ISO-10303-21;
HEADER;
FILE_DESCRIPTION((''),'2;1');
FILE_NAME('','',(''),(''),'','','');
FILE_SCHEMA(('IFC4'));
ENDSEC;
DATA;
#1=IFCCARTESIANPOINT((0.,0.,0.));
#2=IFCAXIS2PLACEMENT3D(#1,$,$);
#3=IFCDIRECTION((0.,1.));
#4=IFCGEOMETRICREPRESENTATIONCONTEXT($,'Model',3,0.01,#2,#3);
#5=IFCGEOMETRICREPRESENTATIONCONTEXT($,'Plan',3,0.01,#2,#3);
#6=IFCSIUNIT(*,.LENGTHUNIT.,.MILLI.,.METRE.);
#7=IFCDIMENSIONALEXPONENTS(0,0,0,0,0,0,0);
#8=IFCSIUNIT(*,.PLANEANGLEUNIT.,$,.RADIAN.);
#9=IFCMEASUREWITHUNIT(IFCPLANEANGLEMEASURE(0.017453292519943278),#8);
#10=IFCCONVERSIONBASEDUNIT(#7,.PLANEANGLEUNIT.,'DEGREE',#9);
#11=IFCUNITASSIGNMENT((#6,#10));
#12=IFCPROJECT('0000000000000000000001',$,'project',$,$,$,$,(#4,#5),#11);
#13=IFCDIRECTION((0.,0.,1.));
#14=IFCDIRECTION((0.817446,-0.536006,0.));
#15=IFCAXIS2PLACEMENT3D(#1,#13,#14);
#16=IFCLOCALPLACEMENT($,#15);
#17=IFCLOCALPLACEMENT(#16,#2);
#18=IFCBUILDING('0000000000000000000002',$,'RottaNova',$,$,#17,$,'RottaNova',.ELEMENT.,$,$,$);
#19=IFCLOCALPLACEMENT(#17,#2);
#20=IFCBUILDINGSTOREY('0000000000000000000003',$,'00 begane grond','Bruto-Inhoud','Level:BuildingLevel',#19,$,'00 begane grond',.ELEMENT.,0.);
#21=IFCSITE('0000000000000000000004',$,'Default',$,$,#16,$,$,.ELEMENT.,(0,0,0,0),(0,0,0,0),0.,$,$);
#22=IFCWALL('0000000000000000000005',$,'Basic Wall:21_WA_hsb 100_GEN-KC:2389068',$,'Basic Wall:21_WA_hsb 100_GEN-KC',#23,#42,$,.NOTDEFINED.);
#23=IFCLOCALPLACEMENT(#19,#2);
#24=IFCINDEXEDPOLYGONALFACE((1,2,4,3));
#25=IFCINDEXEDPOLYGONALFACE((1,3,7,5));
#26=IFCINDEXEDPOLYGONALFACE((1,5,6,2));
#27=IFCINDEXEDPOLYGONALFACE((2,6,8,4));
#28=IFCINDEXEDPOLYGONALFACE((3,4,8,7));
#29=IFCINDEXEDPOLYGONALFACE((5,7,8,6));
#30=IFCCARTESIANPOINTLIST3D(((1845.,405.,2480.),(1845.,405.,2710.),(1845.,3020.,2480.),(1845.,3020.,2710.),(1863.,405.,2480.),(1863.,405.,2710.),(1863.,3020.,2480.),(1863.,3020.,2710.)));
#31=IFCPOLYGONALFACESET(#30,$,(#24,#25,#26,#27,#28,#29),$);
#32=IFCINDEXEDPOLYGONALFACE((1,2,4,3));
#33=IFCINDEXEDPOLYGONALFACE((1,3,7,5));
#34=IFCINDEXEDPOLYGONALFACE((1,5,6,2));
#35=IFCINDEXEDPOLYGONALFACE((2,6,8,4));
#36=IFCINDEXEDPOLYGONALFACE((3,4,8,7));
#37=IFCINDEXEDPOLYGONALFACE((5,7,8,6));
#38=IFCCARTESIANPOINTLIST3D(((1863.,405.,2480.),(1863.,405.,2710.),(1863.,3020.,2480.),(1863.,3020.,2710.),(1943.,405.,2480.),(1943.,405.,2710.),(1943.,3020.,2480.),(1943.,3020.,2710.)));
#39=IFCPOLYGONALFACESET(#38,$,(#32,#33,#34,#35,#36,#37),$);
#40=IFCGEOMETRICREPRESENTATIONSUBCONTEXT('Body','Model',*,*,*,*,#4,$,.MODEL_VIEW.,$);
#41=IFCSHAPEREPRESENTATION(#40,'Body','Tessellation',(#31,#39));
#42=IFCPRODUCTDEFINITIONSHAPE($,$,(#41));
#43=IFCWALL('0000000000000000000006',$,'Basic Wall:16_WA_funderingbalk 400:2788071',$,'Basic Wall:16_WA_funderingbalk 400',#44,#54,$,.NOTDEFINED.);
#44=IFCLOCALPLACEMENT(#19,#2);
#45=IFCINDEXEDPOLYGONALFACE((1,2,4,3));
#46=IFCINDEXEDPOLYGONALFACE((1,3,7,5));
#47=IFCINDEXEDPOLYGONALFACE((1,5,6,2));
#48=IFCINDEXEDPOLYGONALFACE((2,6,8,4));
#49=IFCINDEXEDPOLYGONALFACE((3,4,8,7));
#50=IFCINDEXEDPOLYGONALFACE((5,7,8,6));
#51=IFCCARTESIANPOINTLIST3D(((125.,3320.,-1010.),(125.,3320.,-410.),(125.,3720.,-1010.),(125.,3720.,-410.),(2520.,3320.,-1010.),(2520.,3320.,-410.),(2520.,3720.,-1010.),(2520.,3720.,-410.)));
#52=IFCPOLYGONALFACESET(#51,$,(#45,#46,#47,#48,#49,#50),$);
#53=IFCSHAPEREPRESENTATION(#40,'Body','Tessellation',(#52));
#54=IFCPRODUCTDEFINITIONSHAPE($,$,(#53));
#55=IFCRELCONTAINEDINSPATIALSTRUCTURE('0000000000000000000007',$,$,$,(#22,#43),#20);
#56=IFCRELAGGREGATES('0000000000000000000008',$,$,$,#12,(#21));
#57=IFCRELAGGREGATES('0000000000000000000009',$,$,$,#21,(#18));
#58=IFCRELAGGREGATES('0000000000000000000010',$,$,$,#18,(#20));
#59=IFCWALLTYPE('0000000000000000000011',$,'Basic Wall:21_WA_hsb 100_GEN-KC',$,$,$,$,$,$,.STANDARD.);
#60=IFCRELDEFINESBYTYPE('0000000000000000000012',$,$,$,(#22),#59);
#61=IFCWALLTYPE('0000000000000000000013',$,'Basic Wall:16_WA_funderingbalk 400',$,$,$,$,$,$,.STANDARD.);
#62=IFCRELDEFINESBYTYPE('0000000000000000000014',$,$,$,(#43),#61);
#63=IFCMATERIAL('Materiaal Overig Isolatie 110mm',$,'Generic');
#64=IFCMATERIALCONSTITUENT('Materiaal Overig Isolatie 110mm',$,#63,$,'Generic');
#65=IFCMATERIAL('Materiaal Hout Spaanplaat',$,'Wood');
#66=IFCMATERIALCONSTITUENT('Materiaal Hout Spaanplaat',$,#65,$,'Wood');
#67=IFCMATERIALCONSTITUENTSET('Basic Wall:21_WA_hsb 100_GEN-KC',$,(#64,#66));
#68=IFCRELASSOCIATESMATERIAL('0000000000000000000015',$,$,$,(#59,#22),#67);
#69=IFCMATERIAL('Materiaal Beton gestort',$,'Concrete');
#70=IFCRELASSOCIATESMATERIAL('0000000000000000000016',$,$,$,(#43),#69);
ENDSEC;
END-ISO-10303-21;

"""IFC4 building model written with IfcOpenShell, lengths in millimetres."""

from ifc_helpers import new_model, entity, si_unit, converted_unit, direction, frame, origin, place, context, subcontext, project, spatial, indexed_curve, outline, extrude, material, constituent, constituent_set, type_object, element, save


model = new_model("IFC4")

# Units and contexts
model_context = context("Model", 3, precision=0.01, world=origin(), true_north=direction((0.0, 1.0)))
plan_context = context("Plan", 3, precision=0.01, world=origin(), true_north=direction((0.0, 1.0)))
body_context = subcontext(model_context, "Body", "Model", "MODEL_VIEW")
ifc_project = project(units=[si_unit("LENGTHUNIT", "METRE", prefix="MILLI"), converted_unit("PLANEANGLEUNIT", "DEGREE", entity("IfcPlaneAngleMeasure", 0.017453292519943278), si_unit("PLANEANGLEUNIT", "RADIAN"), dimensions=[0, 0, 0, 0, 0, 0, 0])], contexts=[model_context, plan_context])

# Site, building, storey
site_placement = place(None, frame((0.0, 0.0, 0.0), z_axis=(0.0, 0.0, 1.0), x_axis=(0.817446, -0.536006, 0.0)))
site = spatial("IfcSite", under=ifc_project, at=site_placement, Name="Default", CompositionType="ELEMENT", RefLatitude=(0, 0, 0, 0), RefLongitude=(0, 0, 0, 0), RefElevation=0.0)
building_placement = place(site_placement, origin())
building = spatial("IfcBuilding", under=site, at=building_placement, Name="RottaNova", LongName="RottaNova", CompositionType="ELEMENT")
storey_placement = place(building_placement, origin())
storey = spatial("IfcBuildingStorey", under=building, at=storey_placement, Name="00 begane grond", Description="Bruto-Inhoud", ObjectType="Level:BuildingLevel", LongName="00 begane grond", CompositionType="ELEMENT", Elevation=0.0)

# Walls
ifc_material_1 = material(Name="Materiaal Overig Isolatie 110mm", Category="Generic")
ifc_constituent_1 = constituent(ifc_material_1, Name="Materiaal Overig Isolatie 110mm", Category="Generic")
ifc_material_2 = material(Name="Materiaal Hout Spaanplaat", Category="Wood")
ifc_constituent_2 = constituent(ifc_material_2, Name="Materiaal Hout Spaanplaat", Category="Wood")
ifc_constituent_set = constituent_set(constituents=[ifc_constituent_1, ifc_constituent_2], Name="Basic Wall:21_WA_hsb 100_GEN-KC")
wall_type_1 = type_object("IfcWallType", Name="Basic Wall:21_WA_hsb 100_GEN-KC", PredefinedType="STANDARD", material=ifc_constituent_set)
wall_1_placement = place(storey_placement, frame((1894.0, 3020.0, 2480.0), z_axis=(0.0, 0.0, 1.0), x_axis=(0.0, -1.0, 0.0)))
element("IfcWall", 1, at=wall_1_placement, inside=storey, type_object=wall_type_1, material=ifc_constituent_set, Name="Basic Wall:21_WA_hsb 100_GEN-KC:2389068", ObjectType="Basic Wall:21_WA_hsb 100_GEN-KC", PredefinedType="NOTDEFINED", context=body_context, shape_type="SweptSolid", body=[
    extrude(outline(indexed_curve([(-9.0, -1307.5), (9.0, -1307.5), (9.0, 1307.5), (-9.0, 1307.5), (-9.0, -1307.5)], self_intersect=False)), frame((1307.5, -40.0, 0.0), z_axis=(0.0, 0.0, 1.0), x_axis=(0.0, 1.0, 0.0)), (0.0, 0.0, 1.0), 230.0),
    extrude(outline(indexed_curve([(-40.0, -1307.5), (40.0, -1307.5), (40.0, 1307.5), (-40.0, 1307.5), (-40.0, -1307.5)], self_intersect=False)), frame((1307.5, 9.0, 0.0), z_axis=(0.0, 0.0, 1.0), x_axis=(0.0, -1.0, 0.0)), (0.0, 0.0, 1.0), 230.0),
])
ifc_material_3 = material(Name="Materiaal Beton gestort", Category="Concrete")
wall_type_2 = type_object("IfcWallType", Name="Basic Wall:16_WA_funderingbalk 400", PredefinedType="STANDARD")
wall_2_placement = place(storey_placement, frame((125.0, 3520.0, -1010.0)))
element("IfcWall", 2, at=wall_2_placement, inside=storey, type_object=wall_type_2, material=ifc_material_3, Name="Basic Wall:16_WA_funderingbalk 400:2788071", ObjectType="Basic Wall:16_WA_funderingbalk 400", PredefinedType="NOTDEFINED", context=body_context, shape_type="SweptSolid", body=[
    extrude(outline(indexed_curve([(2395.0, 200.0), (0.0, 200.0), (0.0, -200.0), (2395.0, -200.0), (2395.0, 200.0)], self_intersect=False)), origin(), (0.0, 0.0, 1.0), 600.0),
])

save(model, "model.ifc")
